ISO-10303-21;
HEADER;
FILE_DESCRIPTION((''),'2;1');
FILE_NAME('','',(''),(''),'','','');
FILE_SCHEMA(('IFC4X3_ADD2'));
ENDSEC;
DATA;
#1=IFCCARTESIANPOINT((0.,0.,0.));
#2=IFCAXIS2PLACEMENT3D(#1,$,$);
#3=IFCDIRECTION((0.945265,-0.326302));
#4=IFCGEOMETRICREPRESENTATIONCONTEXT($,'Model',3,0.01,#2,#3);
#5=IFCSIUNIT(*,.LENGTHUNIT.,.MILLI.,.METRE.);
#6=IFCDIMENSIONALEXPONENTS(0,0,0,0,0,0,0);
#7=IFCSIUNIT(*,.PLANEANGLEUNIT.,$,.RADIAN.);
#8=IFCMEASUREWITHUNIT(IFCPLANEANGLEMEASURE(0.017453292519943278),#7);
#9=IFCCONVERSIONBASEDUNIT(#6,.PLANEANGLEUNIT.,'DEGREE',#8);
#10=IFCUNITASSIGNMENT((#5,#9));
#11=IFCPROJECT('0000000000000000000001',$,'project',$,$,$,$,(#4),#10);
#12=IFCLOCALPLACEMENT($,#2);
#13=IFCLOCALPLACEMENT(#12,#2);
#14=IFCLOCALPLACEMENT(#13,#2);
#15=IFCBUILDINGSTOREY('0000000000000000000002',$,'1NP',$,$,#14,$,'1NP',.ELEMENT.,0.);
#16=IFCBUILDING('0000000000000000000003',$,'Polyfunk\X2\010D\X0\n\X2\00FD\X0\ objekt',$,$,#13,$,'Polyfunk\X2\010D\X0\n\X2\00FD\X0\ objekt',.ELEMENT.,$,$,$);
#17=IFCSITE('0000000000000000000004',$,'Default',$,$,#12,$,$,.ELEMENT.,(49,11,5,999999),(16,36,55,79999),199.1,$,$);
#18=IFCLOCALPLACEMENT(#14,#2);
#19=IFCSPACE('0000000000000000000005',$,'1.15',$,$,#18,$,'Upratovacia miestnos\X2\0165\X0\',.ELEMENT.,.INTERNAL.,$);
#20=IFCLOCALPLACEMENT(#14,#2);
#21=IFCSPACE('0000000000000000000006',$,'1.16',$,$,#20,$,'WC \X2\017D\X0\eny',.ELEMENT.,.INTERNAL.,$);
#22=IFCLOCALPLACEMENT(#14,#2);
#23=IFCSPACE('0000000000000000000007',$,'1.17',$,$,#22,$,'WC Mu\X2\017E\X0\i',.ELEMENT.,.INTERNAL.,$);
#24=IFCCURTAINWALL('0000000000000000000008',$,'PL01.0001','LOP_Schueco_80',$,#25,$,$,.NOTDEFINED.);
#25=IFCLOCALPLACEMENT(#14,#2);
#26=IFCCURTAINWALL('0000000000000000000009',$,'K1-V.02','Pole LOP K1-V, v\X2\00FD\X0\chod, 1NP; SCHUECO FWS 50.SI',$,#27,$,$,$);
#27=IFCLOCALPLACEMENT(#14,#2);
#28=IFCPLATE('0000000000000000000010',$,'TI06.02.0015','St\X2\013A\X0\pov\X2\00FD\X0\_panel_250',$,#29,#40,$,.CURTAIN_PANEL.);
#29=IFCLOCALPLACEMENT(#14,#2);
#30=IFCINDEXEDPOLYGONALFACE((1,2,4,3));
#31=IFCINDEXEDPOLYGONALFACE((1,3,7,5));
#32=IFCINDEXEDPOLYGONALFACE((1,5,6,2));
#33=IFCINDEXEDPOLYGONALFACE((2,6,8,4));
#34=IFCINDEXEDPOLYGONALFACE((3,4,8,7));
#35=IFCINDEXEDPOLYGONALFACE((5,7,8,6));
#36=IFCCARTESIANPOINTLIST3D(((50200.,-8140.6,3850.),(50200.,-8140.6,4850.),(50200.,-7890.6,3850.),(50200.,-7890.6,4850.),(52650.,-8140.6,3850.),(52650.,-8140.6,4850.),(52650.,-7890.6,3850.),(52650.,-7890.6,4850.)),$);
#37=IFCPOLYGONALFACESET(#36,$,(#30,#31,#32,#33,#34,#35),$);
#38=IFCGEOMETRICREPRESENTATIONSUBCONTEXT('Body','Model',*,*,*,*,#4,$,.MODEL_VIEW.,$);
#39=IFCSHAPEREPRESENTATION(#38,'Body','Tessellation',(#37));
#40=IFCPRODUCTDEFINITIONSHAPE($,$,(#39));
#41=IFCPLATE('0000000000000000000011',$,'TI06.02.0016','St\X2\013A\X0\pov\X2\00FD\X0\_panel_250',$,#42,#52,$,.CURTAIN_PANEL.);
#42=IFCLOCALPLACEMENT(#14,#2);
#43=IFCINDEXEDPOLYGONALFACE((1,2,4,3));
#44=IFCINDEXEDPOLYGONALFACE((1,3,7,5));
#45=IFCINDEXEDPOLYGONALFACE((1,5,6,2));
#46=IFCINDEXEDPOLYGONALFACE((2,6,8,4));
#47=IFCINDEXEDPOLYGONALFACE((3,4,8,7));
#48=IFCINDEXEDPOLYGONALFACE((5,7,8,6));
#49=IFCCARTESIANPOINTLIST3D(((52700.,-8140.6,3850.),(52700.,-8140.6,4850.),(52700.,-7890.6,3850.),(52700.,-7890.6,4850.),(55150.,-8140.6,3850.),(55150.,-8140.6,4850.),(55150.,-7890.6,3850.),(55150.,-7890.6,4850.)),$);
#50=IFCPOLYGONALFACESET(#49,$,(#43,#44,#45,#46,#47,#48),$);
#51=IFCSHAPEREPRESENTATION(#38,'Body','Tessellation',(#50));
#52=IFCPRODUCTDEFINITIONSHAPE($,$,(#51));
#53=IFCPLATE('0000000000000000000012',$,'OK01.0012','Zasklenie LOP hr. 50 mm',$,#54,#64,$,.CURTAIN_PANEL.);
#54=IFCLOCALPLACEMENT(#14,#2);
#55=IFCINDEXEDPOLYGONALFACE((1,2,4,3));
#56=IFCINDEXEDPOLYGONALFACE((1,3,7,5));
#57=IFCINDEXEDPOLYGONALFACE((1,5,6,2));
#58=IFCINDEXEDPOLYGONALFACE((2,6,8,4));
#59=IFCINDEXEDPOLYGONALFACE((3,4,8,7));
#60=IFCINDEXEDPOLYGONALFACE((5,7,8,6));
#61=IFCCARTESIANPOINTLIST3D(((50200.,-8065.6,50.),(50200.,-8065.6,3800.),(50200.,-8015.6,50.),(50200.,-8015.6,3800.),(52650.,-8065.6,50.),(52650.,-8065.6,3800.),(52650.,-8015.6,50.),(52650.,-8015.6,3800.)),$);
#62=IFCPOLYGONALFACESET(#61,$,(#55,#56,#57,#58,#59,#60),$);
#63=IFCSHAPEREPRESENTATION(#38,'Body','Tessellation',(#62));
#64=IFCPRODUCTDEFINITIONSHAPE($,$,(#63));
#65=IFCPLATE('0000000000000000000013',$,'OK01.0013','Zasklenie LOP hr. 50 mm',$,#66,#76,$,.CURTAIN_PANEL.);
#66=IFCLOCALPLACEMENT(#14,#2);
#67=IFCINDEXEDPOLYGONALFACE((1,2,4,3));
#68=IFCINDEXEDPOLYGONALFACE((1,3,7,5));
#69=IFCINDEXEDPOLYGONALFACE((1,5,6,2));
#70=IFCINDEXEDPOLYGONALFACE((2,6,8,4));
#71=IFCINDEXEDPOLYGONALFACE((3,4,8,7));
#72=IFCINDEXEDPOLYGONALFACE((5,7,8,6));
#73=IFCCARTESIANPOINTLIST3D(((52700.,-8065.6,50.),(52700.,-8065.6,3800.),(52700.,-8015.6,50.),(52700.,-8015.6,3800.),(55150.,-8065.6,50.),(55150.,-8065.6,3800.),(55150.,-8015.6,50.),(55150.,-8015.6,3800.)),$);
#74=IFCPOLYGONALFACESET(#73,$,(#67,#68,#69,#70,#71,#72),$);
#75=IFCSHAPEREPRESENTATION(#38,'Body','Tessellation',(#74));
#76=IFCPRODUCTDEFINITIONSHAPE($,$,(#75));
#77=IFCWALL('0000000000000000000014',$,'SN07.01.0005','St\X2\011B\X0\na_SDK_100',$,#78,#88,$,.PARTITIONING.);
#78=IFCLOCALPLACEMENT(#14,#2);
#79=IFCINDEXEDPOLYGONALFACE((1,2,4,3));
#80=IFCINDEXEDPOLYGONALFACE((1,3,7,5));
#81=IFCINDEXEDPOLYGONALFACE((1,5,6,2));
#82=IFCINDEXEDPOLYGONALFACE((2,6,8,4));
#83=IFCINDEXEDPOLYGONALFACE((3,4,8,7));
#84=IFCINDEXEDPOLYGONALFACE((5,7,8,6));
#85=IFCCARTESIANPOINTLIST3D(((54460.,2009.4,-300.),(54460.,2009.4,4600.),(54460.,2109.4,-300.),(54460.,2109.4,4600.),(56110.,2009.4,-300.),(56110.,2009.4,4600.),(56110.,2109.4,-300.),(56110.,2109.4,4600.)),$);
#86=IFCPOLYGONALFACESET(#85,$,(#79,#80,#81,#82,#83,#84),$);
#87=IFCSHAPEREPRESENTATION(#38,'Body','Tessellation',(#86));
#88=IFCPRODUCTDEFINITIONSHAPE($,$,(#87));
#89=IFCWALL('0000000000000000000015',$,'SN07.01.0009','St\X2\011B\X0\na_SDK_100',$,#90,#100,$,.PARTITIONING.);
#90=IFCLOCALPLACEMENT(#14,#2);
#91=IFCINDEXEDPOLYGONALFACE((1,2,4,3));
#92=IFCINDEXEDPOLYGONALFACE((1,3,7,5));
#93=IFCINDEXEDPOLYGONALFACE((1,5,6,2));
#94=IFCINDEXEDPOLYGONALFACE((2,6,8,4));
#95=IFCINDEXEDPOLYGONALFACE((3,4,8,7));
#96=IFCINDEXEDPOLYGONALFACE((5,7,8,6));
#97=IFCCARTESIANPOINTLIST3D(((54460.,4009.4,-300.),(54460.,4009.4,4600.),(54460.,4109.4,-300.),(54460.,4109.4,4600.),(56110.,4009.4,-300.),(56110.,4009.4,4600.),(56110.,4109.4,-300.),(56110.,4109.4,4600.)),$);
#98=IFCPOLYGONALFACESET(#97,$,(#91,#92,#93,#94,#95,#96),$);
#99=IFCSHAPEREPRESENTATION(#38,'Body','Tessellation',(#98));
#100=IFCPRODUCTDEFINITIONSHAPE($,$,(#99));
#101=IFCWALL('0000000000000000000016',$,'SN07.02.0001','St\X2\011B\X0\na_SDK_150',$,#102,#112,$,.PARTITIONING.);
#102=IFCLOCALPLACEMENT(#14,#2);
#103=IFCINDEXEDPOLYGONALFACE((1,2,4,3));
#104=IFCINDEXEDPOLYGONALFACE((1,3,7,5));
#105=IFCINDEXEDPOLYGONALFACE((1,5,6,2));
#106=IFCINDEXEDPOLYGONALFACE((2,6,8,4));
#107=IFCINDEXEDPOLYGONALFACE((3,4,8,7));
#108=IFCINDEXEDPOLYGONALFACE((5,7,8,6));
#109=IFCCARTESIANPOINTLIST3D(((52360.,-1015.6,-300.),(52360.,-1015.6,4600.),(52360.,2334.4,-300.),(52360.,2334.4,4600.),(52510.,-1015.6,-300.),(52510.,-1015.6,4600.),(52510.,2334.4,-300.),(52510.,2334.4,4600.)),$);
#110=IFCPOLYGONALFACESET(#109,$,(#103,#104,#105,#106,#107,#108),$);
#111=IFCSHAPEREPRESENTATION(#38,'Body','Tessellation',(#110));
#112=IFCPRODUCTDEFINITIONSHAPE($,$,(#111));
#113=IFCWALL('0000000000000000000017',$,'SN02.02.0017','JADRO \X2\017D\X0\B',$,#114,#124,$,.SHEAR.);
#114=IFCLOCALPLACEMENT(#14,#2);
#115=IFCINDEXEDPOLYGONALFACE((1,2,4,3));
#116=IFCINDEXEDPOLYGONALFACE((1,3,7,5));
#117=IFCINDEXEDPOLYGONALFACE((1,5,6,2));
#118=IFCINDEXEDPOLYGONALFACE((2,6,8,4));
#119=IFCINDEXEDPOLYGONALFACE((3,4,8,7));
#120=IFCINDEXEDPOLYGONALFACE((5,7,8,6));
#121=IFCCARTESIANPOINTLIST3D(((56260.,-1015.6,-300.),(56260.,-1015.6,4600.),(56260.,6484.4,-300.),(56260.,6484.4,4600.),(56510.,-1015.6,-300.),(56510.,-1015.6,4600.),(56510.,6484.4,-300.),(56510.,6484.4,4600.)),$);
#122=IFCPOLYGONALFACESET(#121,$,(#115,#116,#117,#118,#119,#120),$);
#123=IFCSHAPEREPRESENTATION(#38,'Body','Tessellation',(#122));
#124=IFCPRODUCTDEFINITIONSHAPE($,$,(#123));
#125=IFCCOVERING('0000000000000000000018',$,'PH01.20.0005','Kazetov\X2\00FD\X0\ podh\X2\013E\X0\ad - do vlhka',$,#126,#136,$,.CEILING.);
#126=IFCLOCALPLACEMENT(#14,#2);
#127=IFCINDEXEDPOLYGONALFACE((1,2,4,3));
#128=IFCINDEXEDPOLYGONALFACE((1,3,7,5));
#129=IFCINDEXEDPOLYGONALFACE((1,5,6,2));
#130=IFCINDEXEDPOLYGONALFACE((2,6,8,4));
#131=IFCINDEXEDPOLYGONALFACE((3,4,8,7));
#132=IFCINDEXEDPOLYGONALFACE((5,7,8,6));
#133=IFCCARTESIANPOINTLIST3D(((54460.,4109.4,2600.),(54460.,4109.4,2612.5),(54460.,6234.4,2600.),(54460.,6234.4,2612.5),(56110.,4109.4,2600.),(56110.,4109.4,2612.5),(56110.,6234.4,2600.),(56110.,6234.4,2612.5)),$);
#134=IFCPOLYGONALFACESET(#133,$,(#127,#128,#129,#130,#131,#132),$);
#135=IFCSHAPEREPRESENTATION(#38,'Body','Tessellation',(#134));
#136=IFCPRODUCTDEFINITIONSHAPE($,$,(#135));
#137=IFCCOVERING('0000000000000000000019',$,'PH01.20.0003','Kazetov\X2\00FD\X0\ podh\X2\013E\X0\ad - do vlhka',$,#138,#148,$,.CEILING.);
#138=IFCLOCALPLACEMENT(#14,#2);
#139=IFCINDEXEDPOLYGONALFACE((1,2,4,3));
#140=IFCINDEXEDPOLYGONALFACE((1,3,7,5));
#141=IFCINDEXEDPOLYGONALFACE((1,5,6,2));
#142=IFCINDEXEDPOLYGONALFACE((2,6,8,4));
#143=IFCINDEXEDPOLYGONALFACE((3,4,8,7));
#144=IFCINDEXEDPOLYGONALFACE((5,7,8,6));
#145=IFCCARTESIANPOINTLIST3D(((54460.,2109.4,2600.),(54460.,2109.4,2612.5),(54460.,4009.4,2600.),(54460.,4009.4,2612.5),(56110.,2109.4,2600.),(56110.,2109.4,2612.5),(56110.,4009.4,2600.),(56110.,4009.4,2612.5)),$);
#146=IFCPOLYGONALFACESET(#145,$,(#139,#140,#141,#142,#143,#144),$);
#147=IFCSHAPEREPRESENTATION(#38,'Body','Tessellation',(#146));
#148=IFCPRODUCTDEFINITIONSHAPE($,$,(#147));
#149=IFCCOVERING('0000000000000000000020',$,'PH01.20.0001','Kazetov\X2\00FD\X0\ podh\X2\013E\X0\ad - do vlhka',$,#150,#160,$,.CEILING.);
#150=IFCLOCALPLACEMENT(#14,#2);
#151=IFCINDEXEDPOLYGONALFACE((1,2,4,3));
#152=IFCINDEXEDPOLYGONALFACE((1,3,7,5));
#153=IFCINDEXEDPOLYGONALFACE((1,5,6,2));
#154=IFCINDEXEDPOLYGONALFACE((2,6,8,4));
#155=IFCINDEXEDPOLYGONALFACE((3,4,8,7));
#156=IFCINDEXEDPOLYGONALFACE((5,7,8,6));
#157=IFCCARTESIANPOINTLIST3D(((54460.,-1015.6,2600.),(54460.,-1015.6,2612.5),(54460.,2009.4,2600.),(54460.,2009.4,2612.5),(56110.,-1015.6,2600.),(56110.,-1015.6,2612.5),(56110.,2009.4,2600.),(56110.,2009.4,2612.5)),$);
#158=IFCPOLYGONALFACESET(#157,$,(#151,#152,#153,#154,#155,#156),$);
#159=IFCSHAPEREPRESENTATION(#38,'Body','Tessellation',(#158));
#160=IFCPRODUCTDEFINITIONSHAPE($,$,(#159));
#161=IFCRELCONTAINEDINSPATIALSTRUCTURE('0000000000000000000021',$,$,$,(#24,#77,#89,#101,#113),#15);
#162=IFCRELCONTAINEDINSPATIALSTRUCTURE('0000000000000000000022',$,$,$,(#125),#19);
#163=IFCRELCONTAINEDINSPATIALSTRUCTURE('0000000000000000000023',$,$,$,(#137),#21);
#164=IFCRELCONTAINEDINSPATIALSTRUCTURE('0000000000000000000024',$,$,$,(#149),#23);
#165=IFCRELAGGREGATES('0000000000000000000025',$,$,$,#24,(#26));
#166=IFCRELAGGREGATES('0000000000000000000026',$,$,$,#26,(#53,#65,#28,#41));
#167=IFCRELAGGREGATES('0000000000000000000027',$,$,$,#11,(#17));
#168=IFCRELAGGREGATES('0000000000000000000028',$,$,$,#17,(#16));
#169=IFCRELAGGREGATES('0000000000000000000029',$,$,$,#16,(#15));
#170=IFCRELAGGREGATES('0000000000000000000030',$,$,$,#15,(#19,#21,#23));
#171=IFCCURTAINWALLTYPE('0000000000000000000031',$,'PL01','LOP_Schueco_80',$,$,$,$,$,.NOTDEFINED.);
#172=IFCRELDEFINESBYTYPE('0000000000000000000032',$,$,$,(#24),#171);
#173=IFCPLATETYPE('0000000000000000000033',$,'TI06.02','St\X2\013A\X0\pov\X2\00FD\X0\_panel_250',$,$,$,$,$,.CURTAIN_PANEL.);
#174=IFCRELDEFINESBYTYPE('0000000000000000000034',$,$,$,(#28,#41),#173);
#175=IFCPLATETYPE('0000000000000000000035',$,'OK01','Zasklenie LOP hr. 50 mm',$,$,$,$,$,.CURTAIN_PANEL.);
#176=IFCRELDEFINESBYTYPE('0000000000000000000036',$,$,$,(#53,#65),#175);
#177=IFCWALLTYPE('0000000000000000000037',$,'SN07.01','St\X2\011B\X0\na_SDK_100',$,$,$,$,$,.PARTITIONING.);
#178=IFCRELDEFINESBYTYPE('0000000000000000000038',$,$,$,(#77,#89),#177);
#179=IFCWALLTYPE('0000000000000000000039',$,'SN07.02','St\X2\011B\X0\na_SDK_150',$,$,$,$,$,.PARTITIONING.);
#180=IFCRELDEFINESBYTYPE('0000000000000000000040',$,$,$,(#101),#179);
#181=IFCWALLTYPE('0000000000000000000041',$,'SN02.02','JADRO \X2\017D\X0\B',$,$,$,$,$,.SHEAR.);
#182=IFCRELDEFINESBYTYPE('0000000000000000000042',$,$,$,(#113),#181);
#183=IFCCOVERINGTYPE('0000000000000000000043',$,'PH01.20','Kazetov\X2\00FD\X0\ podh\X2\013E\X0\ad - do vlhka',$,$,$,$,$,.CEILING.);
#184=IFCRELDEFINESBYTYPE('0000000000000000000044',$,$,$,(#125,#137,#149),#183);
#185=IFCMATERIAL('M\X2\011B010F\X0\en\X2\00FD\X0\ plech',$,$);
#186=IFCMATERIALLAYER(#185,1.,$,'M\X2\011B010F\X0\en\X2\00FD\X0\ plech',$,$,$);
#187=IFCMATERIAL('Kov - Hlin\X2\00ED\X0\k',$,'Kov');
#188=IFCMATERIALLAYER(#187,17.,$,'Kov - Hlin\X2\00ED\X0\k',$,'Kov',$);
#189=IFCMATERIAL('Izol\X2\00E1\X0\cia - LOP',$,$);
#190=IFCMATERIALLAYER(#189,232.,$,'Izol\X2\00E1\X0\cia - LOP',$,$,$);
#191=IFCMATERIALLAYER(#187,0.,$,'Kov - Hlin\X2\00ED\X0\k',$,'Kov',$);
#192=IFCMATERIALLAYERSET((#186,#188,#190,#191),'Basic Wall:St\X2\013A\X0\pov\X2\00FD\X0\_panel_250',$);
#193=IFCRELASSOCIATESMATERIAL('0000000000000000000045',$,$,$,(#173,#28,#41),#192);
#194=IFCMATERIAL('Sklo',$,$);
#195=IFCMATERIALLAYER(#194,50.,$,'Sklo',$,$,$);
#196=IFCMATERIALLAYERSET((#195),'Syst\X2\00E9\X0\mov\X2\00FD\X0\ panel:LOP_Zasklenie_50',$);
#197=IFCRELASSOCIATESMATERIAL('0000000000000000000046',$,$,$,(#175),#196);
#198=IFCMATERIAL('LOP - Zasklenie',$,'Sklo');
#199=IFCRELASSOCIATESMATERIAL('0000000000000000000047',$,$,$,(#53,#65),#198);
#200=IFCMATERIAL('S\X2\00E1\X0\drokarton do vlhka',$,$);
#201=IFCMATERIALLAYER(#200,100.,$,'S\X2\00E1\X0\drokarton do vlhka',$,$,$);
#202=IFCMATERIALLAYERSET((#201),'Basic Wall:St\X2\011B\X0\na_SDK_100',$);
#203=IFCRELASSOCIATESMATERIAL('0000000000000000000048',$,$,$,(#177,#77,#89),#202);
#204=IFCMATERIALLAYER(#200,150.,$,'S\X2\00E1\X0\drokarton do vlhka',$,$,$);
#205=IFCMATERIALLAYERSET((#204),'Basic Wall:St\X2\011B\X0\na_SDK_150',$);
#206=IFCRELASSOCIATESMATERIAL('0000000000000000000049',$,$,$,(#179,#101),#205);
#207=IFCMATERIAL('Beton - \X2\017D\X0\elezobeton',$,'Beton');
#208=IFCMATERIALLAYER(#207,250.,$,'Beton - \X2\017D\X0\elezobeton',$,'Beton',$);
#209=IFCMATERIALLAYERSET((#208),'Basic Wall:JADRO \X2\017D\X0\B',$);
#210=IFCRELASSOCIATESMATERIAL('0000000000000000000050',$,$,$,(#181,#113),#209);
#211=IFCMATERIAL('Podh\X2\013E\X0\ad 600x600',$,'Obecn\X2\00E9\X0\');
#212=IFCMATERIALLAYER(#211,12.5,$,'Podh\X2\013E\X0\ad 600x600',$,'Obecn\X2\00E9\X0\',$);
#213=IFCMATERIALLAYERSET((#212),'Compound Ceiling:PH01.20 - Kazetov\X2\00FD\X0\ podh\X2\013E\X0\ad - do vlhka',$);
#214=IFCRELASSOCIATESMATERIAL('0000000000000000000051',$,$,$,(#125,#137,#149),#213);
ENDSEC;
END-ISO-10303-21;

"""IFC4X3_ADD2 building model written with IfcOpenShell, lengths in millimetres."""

from ifc_helpers import new_model, entity, si_unit, converted_unit, direction, frame, frame_2d, origin, origin_2d_with_axis, place, context, subcontext, project, spatial, polyline, rectangle, extrude, clip, bounded_halfspace, source, transform, mapped, material, layer, layer_set, layer_usage, type_object, type_shapes, element, aggregate, save


model = new_model("IFC4X3_ADD2")

# Units and contexts
model_context = context("Model", 3, precision=0.01, world=origin(), true_north=direction((0.945265, -0.326302)))
body_context = subcontext(model_context, "Body", "Model", "MODEL_VIEW")
ifc_project = project(units=[si_unit("LENGTHUNIT", "METRE", prefix="MILLI"), converted_unit("PLANEANGLEUNIT", "DEGREE", entity("IfcPlaneAngleMeasure", 0.017453292519943278), si_unit("PLANEANGLEUNIT", "RADIAN"), dimensions=[0, 0, 0, 0, 0, 0, 0])], contexts=[model_context])

# Site, building, storey
site_placement = place(None, origin())
site = spatial("IfcSite", under=ifc_project, at=site_placement, Name="Default", CompositionType="ELEMENT", RefLatitude=(49, 11, 5, 999999), RefLongitude=(16, 36, 55, 79999), RefElevation=199.1)
building_placement = place(site_placement, origin())
building = spatial("IfcBuilding", under=site, at=building_placement, Name="Polyfunkčný objekt", LongName="Polyfunkčný objekt", CompositionType="ELEMENT")
storey_placement = place(building_placement, origin())
storey = spatial("IfcBuildingStorey", under=building, at=storey_placement, Name="1NP", LongName="1NP", CompositionType="ELEMENT", Elevation=0.0)

# Curtain walls, plates
curtain_wall_type = type_object("IfcCurtainWallType", Name="PL01", Description="LOP_Schueco_80", PredefinedType="NOTDEFINED")
curtain_wall_1_placement = place(storey_placement, origin())
curtain_wall_1 = element("IfcCurtainWall", 1, at=curtain_wall_1_placement, inside=storey, type_object=curtain_wall_type, Name="PL01.0001", Description="LOP_Schueco_80", PredefinedType="NOTDEFINED")
curtain_wall_2 = element("IfcCurtainWall", 2, Name="K1-V.02", Description="Pole LOP K1-V, východ, 1NP; SCHUECO FWS 50.SI")
aggregate(curtain_wall_1, [curtain_wall_2])
ifc_material_1 = material(Name="Měďený plech")
ifc_layer_1 = layer(ifc_material_1, 1.0, Name="Měďený plech")
ifc_material_2 = material(Name="Kov - Hliník", Category="Kov")
ifc_layer_2 = layer(ifc_material_2, 17.0, Name="Kov - Hliník", Category="Kov")
ifc_material_3 = material(Name="Izolácia - LOP")
ifc_layer_3 = layer(ifc_material_3, 232.0, Name="Izolácia - LOP")
ifc_layer_4 = layer(ifc_material_2, 0.0, Name="Kov - Hliník", Category="Kov")
ifc_layer_set_1 = layer_set([ifc_layer_1, ifc_layer_2, ifc_layer_3, ifc_layer_4], Name="Basic Wall:Stĺpový_panel_250")
ifc_layer_usage_1 = layer_usage(ifc_layer_set_1, "AXIS2", "POSITIVE", -125.0)
plate_type_1 = type_object("IfcPlateType", Name="TI06.02", Description="Stĺpový_panel_250", PredefinedType="CURTAIN_PANEL", material=ifc_layer_set_1)
plate_1_placement = place(storey_placement, frame((50200.0, -8015.6, 3850.0)))
plate_1 = element("IfcPlate", 3, at=plate_1_placement, type_object=plate_type_1, material=ifc_layer_usage_1, Name="TI06.02.0015", Description="Stĺpový_panel_250", PredefinedType="CURTAIN_PANEL", context=body_context, shape_type="SweptSolid", body=[
    extrude(rectangle(XDim=250.0, YDim=2450.0, at=origin_2d_with_axis()), frame((1225.0, 0.0, 0.0), z_axis=(0.0, 0.0, 1.0), x_axis=(0.0, 1.0, 0.0)), (0.0, 0.0, 1.0), 1000.0),
])
ifc_layer_usage_2 = layer_usage(ifc_layer_set_1, "AXIS2", "POSITIVE", -125.0)
plate_2_placement = place(storey_placement, frame((52700.0, -8015.6, 3850.0)))
plate_2 = element("IfcPlate", 4, at=plate_2_placement, type_object=plate_type_1, material=ifc_layer_usage_2, Name="TI06.02.0016", Description="Stĺpový_panel_250", PredefinedType="CURTAIN_PANEL", context=body_context, shape_type="SweptSolid", body=[
    extrude(rectangle(XDim=250.0, YDim=2450.0, at=frame_2d((0.0, 0.0), x_axis=(1.0, 0.0))), frame((1225.0, 0.0, 0.0), z_axis=(0.0, 0.0, 1.0), x_axis=(0.0, 1.0, 0.0)), (0.0, 0.0, 1.0), 1000.0),
])
ifc_material_4 = material(Name="LOP - Zasklenie", Category="Sklo")
ifc_material_5 = material(Name="Sklo")
ifc_layer_5 = layer(ifc_material_5, 50.0, Name="Sklo")
ifc_layer_set_2 = layer_set([ifc_layer_5], Name="Systémový panel:LOP_Zasklenie_50")
plate_type_2 = type_object("IfcPlateType", Name="OK01", Description="Zasklenie LOP hr. 50 mm", PredefinedType="CURTAIN_PANEL", material=ifc_layer_set_2)
shared_shape_1 = source(origin(), body_context, "Body", "SweptSolid", [
    extrude(rectangle(XDim=3750.0, YDim=2450.0, at=frame_2d((-331.2, 0.0), x_axis=(1.0, 0.0))), frame((0.0, -50.0, 2206.2), z_axis=(0.0, 1.0, 0.0), x_axis=(0.0, 0.0, 1.0)), (0.0, 0.0, 1.0), 50.0),
])
type_shapes(plate_type_2, [shared_shape_1])
plate_3_placement = place(curtain_wall_1_placement, frame((51425.0, -8015.6, 50.0)))
plate_3 = element("IfcPlate", 5, at=plate_3_placement, type_object=plate_type_2, material=ifc_material_4, Name="OK01.0012", Description="Zasklenie LOP hr. 50 mm", PredefinedType="CURTAIN_PANEL", context=body_context, shape_type="MappedRepresentation", body=[
    mapped(shared_shape_1, transform((0.0, 0.0, 0.0), scale=1.0)),
])
plate_4_placement = place(curtain_wall_1_placement, frame((53925.0, -8015.6, 50.0)))
plate_4 = element("IfcPlate", 6, at=plate_4_placement, type_object=plate_type_2, material=ifc_material_4, Name="OK01.0013", Description="Zasklenie LOP hr. 50 mm", PredefinedType="CURTAIN_PANEL", context=body_context, shape_type="MappedRepresentation", body=[
    mapped(shared_shape_1, transform((0.0, 0.0, 0.0), scale=1.0)),
])
aggregate(curtain_wall_2, [plate_3, plate_4, plate_1, plate_2])

# Walls
ifc_material_6 = material(Name="Sádrokarton do vlhka")
ifc_layer_6 = layer(ifc_material_6, 100.0, Name="Sádrokarton do vlhka")
ifc_layer_set_3 = layer_set([ifc_layer_6], Name="Basic Wall:Stěna_SDK_100")
wall_type_1 = type_object("IfcWallType", Name="SN07.01", Description="Stěna_SDK_100", PredefinedType="PARTITIONING", material=ifc_layer_set_3)
wall_1_placement = place(storey_placement, frame((54460.0, 2059.4, -300.0)))
element("IfcWall", 7, at=wall_1_placement, inside=storey, type_object=wall_type_1, material=ifc_layer_set_3, Name="SN07.01.0005", Description="Stěna_SDK_100", PredefinedType="PARTITIONING", context=body_context, shape_type="Clipping", body=[
    clip(clip(extrude(rectangle(XDim=1650.0, YDim=100.0, at=frame_2d((825.0, 0.0), x_axis=(-1.0, 0.0))), origin(), (0.0, 0.0, 1.0), 4900.0), bounded_halfspace(frame((0.0, -50.0, 4900.0), z_axis=(0.0, 0.0, -1.0), x_axis=(1.0, 0.0, 0.0)), True, frame((0.0, -50.0, 4900.0)), polyline([(0.0, 0.0), (1650.0, 0.0), (1650.0, 100.0), (0.0, 100.0), (0.0, 0.0)]))), bounded_halfspace(frame((1650.0, -50.0, 0.0), z_axis=(0.0, 0.0, 1.0), x_axis=(0.0, 1.0, 0.0)), True, frame((1650.0, -50.0, 0.0)), polyline([(0.0, 0.0), (0.0, 100.0), (-1650.0, 100.0), (-1650.0, 0.0), (0.0, 0.0)]))),
])
wall_2_placement = place(storey_placement, frame((54460.0, 4059.4, -300.0)))
element("IfcWall", 8, at=wall_2_placement, inside=storey, type_object=wall_type_1, material=ifc_layer_set_3, Name="SN07.01.0009", Description="Stěna_SDK_100", PredefinedType="PARTITIONING", context=body_context, shape_type="Clipping", body=[
    clip(clip(extrude(rectangle(XDim=1650.0, YDim=100.0, at=frame_2d((825.0, 0.0), x_axis=(-1.0, 0.0))), origin(), (0.0, 0.0, 1.0), 4900.0), bounded_halfspace(frame((0.0, -50.0, 4900.0), z_axis=(0.0, 0.0, -1.0), x_axis=(1.0, 0.0, 0.0)), True, frame((0.0, -50.0, 4900.0)), polyline([(0.0, 0.0), (1650.0, 0.0), (1650.0, 100.0), (0.0, 100.0), (0.0, 0.0)]))), bounded_halfspace(frame((1650.0, -50.0, 0.0), z_axis=(0.0, 0.0, 1.0), x_axis=(0.0, 1.0, 0.0)), True, frame((1650.0, -50.0, 0.0)), polyline([(0.0, 0.0), (0.0, 100.0), (-1650.0, 100.0), (-1650.0, 0.0), (0.0, 0.0)]))),
])
ifc_layer_7 = layer(ifc_material_6, 150.0, Name="Sádrokarton do vlhka")
ifc_layer_set_4 = layer_set([ifc_layer_7], Name="Basic Wall:Stěna_SDK_150")
wall_type_2 = type_object("IfcWallType", Name="SN07.02", Description="Stěna_SDK_150", PredefinedType="PARTITIONING", material=ifc_layer_set_4)
wall_3_placement = place(storey_placement, frame((52435.0, 2334.4, -300.0), z_axis=(0.0, 0.0, 1.0), x_axis=(0.0, -1.0, 0.0)))
element("IfcWall", 9, at=wall_3_placement, inside=storey, type_object=wall_type_2, material=ifc_layer_set_4, Name="SN07.02.0001", Description="Stěna_SDK_150", PredefinedType="PARTITIONING", context=body_context, shape_type="Clipping", body=[
    clip(clip(extrude(rectangle(XDim=3350.0, YDim=150.0, at=frame_2d((1675.0, 0.0), x_axis=(-1.0, 0.0))), origin(), (0.0, 0.0, 1.0), 4900.0), bounded_halfspace(frame((3350.0, -75.0, 0.0), z_axis=(0.0, 0.0, 1.0), x_axis=(-1.0, 0.0, 0.0)), True, frame((3350.0, -75.0, 0.0)), polyline([(0.0, 0.0), (0.0, 150.0), (-3350.0, 150.0), (-3350.0, 0.0), (0.0, 0.0)]))), bounded_halfspace(frame((0.0, -75.0, 4900.0), z_axis=(0.0, 0.0, -1.0), x_axis=(0.0, 1.0, 0.0)), True, frame((0.0, -75.0, 4900.0)), polyline([(0.0, 0.0), (3350.0, 0.0), (3350.0, 150.0), (0.0, 150.0), (0.0, 0.0)]))),
])
ifc_material_7 = material(Name="Beton - Železobeton", Category="Beton")
ifc_layer_8 = layer(ifc_material_7, 250.0, Name="Beton - Železobeton", Category="Beton")
ifc_layer_set_5 = layer_set([ifc_layer_8], Name="Basic Wall:JADRO ŽB")
wall_type_3 = type_object("IfcWallType", Name="SN02.02", Description="JADRO ŽB", PredefinedType="SHEAR", material=ifc_layer_set_5)
wall_4_placement = place(storey_placement, frame((56385.0, -1015.6, -300.0), z_axis=(0.0, 0.0, 1.0), x_axis=(0.0, 1.0, 0.0)))
element("IfcWall", 10, at=wall_4_placement, inside=storey, type_object=wall_type_3, material=ifc_layer_set_5, Name="SN02.02.0017", Description="JADRO ŽB", PredefinedType="SHEAR", context=body_context, shape_type="Clipping", body=[
    clip(clip(extrude(rectangle(XDim=7500.0, YDim=250.0, at=frame_2d((3750.0, 0.0), x_axis=(-1.0, 0.0))), origin(), (0.0, 0.0, 1.0), 4900.0), bounded_halfspace(frame((0.0, -125.0, 4900.0), z_axis=(0.0, 0.0, -1.0), x_axis=(0.0, -1.0, 0.0)), True, frame((0.0, -125.0, 4900.0)), polyline([(0.0, 0.0), (7500.0, 0.0), (7500.0, 250.0), (7250.0, 250.0), (0.0, 250.0), (0.0, 0.0)]))), bounded_halfspace(frame((0.0, -125.0, 0.0)), True, frame((0.0, -125.0, 0.0)), polyline([(0.0, 0.0), (7110.0, 0.0), (7500.0, 0.0), (7500.0, 250.0), (7250.0, 250.0), (0.0, 250.0), (0.0, 0.0)]))),
])

# Shared definitions
ifc_material_8 = material(Name="Podhľad 600x600", Category="Obecné")

# Shared definitions
space_1_placement = place(storey_placement, origin())
space_1 = spatial("IfcSpace", under=storey, at=space_1_placement, Name="1.15", LongName="Upratovacia miestnosť", CompositionType="ELEMENT", PredefinedType="INTERNAL")

# Covering
ifc_layer_9 = layer(ifc_material_8, 12.5, Name="Podhľad 600x600", Category="Obecné")
ifc_layer_set_6 = layer_set([ifc_layer_9], Name="Compound Ceiling:PH01.20 - Kazetový podhľad - do vlhka")
ifc_layer_usage_3 = layer_usage(ifc_layer_set_6, "AXIS3", "NEGATIVE", 0.0)
covering_type_1 = type_object("IfcCoveringType", Name="PH01.20", Description="Kazetový podhľad - do vlhka", PredefinedType="CEILING")
covering_1_placement = place(storey_placement, frame((54460.0, 4109.4, 2600.0)))
element("IfcCovering", 11, at=covering_1_placement, inside=space_1, type_object=covering_type_1, material=ifc_layer_usage_3, Name="PH01.20.0005", Description="Kazetový podhľad - do vlhka", PredefinedType="CEILING", context=body_context, shape_type="SweptSolid", body=[
    extrude(rectangle(XDim=2125.0, YDim=1650.0, at=frame_2d((0.0, 0.0), x_axis=(1.0, 0.0))), frame((825.0, 1062.5, 0.0), z_axis=(0.0, 0.0, 1.0), x_axis=(0.0, -1.0, 0.0)), (0.0, 0.0, 1.0), 12.5),
])

# Shared definitions
space_2_placement = place(storey_placement, origin())
space_2 = spatial("IfcSpace", under=storey, at=space_2_placement, Name="1.16", LongName="WC Ženy", CompositionType="ELEMENT", PredefinedType="INTERNAL")

# Covering
ifc_layer_usage_4 = layer_usage(ifc_layer_set_6, "AXIS3", "NEGATIVE", 0.0)
covering_2_placement = place(storey_placement, frame((54460.0, 2109.4, 2600.0)))
element("IfcCovering", 12, at=covering_2_placement, inside=space_2, type_object=covering_type_1, material=ifc_layer_usage_4, Name="PH01.20.0003", Description="Kazetový podhľad - do vlhka", PredefinedType="CEILING", context=body_context, shape_type="SweptSolid", body=[
    extrude(rectangle(XDim=1900.0, YDim=1650.0, at=frame_2d((0.0, 0.0), x_axis=(1.0, 0.0))), frame((825.0, 950.0, 0.0), z_axis=(0.0, 0.0, 1.0), x_axis=(0.0, 1.0, 0.0)), (0.0, 0.0, 1.0), 12.5),
])

# Shared definitions
space_3_placement = place(storey_placement, origin())
space_3 = spatial("IfcSpace", under=storey, at=space_3_placement, Name="1.17", LongName="WC Muži", CompositionType="ELEMENT", PredefinedType="INTERNAL")

# Covering
ifc_layer_usage_5 = layer_usage(ifc_layer_set_6, "AXIS3", "NEGATIVE", 0.0)
covering_3_placement = place(storey_placement, frame((54460.0, -1015.6, 2600.0)))
element("IfcCovering", 13, at=covering_3_placement, inside=space_3, type_object=covering_type_1, material=ifc_layer_usage_5, Name="PH01.20.0001", Description="Kazetový podhľad - do vlhka", PredefinedType="CEILING", context=body_context, shape_type="SweptSolid", body=[
    extrude(rectangle(XDim=1650.0, YDim=3025.0, at=frame_2d((0.0, 0.0), x_axis=(1.0, 0.0))), frame((825.0, 1512.5, 0.0), z_axis=(0.0, 0.0, 1.0), x_axis=(-1.0, 0.0, 0.0)), (0.0, 0.0, 1.0), 12.5),
])

save(model, "model.ifc")
